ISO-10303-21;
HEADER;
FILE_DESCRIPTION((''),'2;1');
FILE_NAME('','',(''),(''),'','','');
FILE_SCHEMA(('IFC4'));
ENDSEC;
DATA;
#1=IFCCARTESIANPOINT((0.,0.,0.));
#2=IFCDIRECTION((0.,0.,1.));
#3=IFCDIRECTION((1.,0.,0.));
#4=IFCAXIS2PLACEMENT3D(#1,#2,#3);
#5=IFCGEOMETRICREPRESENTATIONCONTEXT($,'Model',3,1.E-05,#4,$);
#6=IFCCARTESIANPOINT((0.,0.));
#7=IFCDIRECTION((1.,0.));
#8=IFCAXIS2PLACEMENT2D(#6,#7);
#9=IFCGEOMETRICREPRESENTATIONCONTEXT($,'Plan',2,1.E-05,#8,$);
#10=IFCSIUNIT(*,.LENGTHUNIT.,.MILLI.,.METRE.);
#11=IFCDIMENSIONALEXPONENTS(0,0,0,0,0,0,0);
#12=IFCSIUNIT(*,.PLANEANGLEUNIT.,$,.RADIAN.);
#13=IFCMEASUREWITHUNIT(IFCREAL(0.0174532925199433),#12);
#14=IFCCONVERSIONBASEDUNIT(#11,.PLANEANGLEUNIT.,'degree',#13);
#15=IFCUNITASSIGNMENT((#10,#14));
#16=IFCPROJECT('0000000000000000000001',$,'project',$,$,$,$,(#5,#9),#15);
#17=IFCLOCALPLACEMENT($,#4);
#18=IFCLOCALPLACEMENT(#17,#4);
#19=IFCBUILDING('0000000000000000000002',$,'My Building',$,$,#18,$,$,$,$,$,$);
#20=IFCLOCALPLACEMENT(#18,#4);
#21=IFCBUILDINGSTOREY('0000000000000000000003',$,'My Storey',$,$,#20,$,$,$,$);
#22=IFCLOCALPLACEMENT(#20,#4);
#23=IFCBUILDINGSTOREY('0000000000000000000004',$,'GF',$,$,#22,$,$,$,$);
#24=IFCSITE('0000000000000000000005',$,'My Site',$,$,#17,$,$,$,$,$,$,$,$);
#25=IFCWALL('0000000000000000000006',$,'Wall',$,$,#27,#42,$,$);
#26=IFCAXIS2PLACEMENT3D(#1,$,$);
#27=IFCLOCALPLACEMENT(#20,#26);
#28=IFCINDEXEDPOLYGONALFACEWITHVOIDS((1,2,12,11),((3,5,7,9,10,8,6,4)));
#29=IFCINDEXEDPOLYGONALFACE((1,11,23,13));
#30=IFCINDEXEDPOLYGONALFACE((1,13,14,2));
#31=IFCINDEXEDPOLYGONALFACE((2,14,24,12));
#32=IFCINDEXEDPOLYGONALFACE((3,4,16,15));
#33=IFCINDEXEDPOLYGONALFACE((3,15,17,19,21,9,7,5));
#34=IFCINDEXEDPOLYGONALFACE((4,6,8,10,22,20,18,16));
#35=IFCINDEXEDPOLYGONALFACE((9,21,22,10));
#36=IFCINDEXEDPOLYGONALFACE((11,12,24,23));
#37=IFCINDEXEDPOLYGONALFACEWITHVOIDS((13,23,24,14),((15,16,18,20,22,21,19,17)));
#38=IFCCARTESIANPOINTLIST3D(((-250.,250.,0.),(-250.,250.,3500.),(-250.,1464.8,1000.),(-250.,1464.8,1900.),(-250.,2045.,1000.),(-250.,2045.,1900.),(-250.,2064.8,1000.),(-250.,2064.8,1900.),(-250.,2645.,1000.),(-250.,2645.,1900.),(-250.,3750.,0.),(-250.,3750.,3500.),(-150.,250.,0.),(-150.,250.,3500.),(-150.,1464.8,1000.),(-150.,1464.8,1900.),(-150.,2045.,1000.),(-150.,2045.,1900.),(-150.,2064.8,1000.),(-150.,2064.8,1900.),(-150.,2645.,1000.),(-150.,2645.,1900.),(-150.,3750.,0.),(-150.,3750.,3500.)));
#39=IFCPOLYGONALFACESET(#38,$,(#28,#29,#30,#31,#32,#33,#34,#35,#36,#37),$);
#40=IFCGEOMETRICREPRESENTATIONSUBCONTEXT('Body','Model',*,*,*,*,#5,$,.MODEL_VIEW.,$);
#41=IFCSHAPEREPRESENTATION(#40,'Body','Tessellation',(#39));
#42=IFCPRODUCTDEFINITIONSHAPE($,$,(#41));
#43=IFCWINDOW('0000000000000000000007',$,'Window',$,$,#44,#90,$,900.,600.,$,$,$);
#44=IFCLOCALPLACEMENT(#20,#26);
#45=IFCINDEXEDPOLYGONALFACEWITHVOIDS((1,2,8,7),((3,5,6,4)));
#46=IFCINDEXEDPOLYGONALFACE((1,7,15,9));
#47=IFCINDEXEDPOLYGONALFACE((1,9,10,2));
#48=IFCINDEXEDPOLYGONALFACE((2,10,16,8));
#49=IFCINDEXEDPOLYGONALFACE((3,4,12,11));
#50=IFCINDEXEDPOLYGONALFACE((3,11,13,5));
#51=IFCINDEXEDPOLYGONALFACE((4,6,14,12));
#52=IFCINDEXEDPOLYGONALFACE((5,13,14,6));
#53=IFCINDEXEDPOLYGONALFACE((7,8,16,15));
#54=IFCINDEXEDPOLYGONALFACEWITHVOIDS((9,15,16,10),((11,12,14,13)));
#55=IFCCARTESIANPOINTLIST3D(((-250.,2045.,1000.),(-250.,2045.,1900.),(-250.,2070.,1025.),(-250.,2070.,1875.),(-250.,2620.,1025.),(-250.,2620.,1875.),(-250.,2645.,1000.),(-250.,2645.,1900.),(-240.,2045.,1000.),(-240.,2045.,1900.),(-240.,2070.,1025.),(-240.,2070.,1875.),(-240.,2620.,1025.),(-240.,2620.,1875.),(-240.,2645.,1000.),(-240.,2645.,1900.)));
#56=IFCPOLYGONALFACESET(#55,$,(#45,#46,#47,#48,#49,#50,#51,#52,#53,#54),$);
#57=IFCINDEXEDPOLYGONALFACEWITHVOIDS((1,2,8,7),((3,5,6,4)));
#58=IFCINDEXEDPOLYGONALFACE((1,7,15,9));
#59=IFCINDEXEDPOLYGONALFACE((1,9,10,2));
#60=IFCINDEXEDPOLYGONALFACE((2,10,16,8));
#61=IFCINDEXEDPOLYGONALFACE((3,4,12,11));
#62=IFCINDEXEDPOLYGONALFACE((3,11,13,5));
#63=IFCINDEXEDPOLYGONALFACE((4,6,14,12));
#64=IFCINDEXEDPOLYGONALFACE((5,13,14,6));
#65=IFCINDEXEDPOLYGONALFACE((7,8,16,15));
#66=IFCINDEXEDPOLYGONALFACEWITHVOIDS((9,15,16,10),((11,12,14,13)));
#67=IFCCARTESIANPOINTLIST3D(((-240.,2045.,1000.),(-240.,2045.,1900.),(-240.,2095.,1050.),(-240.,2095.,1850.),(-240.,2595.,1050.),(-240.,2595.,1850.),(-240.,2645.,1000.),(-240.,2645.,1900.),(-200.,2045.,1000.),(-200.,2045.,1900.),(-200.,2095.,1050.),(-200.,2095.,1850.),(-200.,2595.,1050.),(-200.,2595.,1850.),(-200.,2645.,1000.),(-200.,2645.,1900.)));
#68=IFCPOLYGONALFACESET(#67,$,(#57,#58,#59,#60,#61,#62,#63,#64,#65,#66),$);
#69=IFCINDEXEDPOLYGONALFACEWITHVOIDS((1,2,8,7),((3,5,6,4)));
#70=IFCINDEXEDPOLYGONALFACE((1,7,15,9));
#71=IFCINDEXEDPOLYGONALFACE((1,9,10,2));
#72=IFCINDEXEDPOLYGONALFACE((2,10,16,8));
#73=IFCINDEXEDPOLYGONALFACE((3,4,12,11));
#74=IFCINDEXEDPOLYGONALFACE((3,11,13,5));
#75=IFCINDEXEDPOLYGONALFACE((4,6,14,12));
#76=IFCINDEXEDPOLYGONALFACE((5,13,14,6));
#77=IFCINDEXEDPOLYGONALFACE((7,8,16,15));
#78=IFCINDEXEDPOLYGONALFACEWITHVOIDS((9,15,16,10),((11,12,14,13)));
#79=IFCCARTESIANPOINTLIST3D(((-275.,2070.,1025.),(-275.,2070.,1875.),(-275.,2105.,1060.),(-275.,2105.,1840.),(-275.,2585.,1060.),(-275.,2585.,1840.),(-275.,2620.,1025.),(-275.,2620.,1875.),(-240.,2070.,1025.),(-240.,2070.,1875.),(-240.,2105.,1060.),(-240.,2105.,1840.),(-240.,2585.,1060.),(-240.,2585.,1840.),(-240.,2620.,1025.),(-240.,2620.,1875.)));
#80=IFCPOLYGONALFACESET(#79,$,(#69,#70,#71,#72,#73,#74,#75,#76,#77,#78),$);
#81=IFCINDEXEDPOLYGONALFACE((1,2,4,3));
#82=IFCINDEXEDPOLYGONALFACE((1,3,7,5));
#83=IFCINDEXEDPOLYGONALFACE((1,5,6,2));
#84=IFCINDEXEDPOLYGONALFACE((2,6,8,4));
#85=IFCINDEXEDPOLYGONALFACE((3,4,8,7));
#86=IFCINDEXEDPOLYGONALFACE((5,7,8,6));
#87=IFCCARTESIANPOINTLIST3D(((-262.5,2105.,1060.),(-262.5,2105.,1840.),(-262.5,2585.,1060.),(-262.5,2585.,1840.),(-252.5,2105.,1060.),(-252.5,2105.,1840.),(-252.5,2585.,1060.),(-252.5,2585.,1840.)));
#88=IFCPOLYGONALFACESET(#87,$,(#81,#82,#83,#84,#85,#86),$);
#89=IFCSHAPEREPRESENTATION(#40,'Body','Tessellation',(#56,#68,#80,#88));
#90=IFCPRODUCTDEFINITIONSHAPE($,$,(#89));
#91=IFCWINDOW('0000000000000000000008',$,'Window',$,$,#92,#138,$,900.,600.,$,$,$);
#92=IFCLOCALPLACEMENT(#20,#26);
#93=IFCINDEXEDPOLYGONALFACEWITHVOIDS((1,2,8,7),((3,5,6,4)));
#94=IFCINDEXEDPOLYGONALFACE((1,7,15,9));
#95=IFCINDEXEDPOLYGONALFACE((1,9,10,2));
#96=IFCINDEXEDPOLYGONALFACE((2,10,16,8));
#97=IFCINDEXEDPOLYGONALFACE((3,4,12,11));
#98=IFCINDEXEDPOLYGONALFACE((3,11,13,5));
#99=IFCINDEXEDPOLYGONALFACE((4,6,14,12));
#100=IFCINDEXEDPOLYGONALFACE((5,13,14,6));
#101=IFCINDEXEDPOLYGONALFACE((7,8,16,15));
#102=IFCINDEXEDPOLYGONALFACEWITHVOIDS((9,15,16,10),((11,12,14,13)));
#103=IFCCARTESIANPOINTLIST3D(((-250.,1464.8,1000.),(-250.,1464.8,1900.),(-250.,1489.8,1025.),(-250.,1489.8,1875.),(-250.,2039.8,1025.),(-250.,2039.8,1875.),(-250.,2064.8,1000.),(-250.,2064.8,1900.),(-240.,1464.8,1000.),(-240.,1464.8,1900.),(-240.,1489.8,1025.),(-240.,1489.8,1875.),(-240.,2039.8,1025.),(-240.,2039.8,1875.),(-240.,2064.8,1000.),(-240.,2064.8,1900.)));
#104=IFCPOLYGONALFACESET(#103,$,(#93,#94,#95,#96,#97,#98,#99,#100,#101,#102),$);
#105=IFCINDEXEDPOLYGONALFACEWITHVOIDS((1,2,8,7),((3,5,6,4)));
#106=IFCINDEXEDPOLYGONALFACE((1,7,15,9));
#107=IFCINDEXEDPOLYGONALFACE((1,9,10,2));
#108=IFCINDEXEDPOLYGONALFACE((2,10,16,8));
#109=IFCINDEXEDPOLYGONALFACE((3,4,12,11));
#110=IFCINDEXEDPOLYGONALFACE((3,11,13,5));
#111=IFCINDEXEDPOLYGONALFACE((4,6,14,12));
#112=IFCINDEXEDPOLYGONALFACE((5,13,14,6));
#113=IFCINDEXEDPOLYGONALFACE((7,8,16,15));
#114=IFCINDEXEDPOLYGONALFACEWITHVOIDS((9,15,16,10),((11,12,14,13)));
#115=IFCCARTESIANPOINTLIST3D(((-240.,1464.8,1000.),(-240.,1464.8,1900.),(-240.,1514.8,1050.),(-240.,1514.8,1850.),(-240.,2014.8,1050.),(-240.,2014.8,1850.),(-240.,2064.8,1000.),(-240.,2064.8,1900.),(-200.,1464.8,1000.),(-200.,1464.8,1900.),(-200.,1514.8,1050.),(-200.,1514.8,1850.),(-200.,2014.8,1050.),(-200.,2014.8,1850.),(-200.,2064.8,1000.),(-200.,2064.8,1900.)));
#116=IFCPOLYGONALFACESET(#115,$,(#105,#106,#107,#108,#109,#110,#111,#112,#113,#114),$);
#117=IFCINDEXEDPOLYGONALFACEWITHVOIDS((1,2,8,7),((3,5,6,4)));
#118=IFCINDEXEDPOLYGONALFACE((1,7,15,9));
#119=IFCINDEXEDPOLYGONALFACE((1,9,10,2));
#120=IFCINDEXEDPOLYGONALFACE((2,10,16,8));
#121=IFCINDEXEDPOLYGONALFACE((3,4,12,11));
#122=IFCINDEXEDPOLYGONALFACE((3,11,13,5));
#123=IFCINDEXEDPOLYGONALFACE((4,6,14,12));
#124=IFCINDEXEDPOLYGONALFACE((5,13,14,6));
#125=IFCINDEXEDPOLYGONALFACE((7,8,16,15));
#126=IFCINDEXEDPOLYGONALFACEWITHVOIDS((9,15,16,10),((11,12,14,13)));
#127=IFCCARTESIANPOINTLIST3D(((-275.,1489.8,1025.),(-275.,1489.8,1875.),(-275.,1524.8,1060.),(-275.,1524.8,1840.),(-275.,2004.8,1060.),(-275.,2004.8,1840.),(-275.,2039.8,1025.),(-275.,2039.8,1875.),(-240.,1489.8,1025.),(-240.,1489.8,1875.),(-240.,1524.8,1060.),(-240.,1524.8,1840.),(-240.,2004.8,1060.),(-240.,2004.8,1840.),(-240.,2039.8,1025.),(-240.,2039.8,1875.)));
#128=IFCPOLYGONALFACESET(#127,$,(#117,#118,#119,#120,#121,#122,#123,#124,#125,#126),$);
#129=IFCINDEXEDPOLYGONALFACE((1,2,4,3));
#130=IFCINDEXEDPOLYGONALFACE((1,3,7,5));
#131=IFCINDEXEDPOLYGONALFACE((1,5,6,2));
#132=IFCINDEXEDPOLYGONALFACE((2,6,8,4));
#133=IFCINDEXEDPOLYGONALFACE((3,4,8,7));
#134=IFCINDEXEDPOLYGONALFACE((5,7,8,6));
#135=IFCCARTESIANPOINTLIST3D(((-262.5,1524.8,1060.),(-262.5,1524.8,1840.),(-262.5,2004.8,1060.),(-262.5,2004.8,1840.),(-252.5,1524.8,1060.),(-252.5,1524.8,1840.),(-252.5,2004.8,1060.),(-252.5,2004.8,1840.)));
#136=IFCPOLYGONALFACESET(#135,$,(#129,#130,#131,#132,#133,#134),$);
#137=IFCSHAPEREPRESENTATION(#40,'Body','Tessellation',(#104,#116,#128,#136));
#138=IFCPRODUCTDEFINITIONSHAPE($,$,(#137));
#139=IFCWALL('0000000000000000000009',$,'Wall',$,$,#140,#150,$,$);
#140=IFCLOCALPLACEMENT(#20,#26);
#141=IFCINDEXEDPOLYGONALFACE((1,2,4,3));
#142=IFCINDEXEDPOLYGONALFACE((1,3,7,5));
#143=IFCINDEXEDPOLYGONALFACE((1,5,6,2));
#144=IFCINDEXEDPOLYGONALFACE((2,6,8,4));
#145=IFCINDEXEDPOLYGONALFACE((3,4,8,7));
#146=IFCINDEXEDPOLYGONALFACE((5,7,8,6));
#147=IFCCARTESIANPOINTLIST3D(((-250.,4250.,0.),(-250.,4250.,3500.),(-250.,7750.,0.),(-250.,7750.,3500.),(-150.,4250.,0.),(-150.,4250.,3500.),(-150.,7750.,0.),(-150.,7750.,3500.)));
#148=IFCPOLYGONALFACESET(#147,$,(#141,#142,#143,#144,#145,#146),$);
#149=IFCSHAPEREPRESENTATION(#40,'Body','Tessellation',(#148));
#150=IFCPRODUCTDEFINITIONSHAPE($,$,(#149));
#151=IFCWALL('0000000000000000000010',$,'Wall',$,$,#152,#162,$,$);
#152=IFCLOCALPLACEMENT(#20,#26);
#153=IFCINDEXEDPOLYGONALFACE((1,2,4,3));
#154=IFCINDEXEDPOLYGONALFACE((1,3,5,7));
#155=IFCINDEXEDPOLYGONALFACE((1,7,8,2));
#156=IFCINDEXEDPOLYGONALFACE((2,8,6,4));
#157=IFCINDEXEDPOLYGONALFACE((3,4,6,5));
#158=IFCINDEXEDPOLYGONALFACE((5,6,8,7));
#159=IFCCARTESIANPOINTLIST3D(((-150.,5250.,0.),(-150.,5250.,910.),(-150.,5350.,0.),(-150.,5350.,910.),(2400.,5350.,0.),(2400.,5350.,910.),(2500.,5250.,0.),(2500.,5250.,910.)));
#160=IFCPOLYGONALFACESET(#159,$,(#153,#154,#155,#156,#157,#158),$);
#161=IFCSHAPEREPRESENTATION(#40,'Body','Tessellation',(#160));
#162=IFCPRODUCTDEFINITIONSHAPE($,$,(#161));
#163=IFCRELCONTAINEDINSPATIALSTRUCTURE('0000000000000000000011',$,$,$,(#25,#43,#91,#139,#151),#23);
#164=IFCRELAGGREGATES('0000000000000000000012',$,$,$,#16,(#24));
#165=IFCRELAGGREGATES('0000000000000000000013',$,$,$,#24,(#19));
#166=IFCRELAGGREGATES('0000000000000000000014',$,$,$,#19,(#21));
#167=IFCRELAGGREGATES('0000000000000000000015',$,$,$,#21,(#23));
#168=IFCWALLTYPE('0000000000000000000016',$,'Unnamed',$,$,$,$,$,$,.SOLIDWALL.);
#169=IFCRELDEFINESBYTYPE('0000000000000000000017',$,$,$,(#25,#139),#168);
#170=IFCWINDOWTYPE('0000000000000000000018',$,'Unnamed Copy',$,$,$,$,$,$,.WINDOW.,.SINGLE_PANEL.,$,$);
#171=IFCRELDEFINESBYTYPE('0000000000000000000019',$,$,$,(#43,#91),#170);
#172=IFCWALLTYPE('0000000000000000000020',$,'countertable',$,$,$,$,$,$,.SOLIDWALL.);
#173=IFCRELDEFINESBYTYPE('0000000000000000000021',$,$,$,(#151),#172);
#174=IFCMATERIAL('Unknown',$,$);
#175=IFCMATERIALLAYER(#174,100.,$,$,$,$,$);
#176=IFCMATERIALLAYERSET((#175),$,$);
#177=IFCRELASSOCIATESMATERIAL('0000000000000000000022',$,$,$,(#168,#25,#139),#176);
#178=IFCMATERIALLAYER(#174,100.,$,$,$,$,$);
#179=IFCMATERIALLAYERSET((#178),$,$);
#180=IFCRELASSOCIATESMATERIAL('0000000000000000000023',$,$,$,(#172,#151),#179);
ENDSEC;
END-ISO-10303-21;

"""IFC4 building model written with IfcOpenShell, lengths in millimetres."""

from ifc_helpers import new_model, entity, si_unit, converted_unit, frame, origin_with_axes, origin_2d_with_axis, place, context, subcontext, project, spatial, line, indexed_curve, outline, extrude, shape, source, transform, mapped, material, layer, layer_set, layer_usage, type_object, type_shapes, element, fill, save


model = new_model("IFC4")

# Units and contexts
model_context = context("Model", 3, precision=1e-05, world=origin_with_axes())
plan_context = context("Plan", 2, precision=1e-05, world=origin_2d_with_axis())
body_context_1 = subcontext(model_context, "Body", "Model", "MODEL_VIEW")
body_context_2 = subcontext(plan_context, "Body", "Plan", "PLAN_VIEW")
ifc_project = project(units=[si_unit("LENGTHUNIT", "METRE", prefix="MILLI"), converted_unit("PLANEANGLEUNIT", "degree", entity("IfcReal", 0.0174532925199433), si_unit("PLANEANGLEUNIT", "RADIAN"), dimensions=[0, 0, 0, 0, 0, 0, 0])], contexts=[model_context, plan_context])

# Site, building, storeys
site_placement = place(None, origin_with_axes())
site = spatial("IfcSite", under=ifc_project, at=site_placement, Name="My Site")
building_placement = place(site_placement, origin_with_axes())
building = spatial("IfcBuilding", under=site, at=building_placement, Name="My Building")
storey_1_placement = place(building_placement, origin_with_axes())
storey_1 = spatial("IfcBuildingStorey", under=building, at=storey_1_placement, Name="My Storey")
storey_2_placement = place(storey_1_placement, origin_with_axes())
storey_2 = spatial("IfcBuildingStorey", under=storey_1, at=storey_2_placement, Name="GF")

# Shared definitions
ifc_material = material(Name="Unknown")

# Shared definitions
ifc_layer_1 = layer(ifc_material, 100.0)
ifc_layer_set_1 = layer_set([ifc_layer_1])
wall_type_1 = type_object("IfcWallType", Name="Unnamed", PredefinedType="SOLIDWALL", material=ifc_layer_set_1)

# Wall, openings, windows
ifc_layer_usage_1 = layer_usage(ifc_layer_set_1, "AXIS2", "POSITIVE", 0.0)
wall_1_placement = place(storey_2_placement, frame((-150.0, 250.0, 0.0), z_axis=(0.0, 0.0, 1.0), x_axis=(0.0, 1.0, 0.0)))
wall_1 = element("IfcWall", 1, at=wall_1_placement, inside=storey_2, type_object=wall_type_1, material=ifc_layer_usage_1, Name="Wall", context=body_context_1, shape_type="SweptSolid", body=[
    extrude(outline(indexed_curve([(0.0, 0.0), (0.0, 100.0), (3500.0, 100.0), (3500.0, 0.0)], segments=[line(1, 2, 3, 4, 1)])), origin_with_axes(), (0.0, 0.0, 1.0), 3500.0),
])
shared_shape_1 = source(origin_with_axes(), body_context_1, "Body", "SweptSolid", [
    extrude(outline(indexed_curve([(0.0, 0.0), (600.0, 0.0), (600.0, 900.0), (0.0, 900.0)], segments=[line(1, 2, 3, 4, 1)])), frame((0.0, -600.0, 0.0), z_axis=(0.0, -1.0, 0.0), x_axis=(1.0, 0.0, 0.0)), (0.0, 0.0, -1.0), 1200.0),
])
opening_1_placement = place(wall_1_placement, frame((1795.0, 0.0, 1000.0), z_axis=(0.0, 0.0, 1.0), x_axis=(1.0, 0.0, 0.0)))
opening_1 = element("IfcOpeningElement", 2, at=opening_1_placement, cuts=wall_1, PredefinedType="OPENING", context=body_context_1, shape_type="MappedRepresentation", body=[
    mapped(shared_shape_1, transform((0.0, 0.0, 0.0), x_axis=(1.0, 0.0, 0.0), y_axis=(0.0, 1.0, 0.0), z_axis=(0.0, 0.0, 1.0), scale=1.0)),
])
opening_2_placement = place(wall_1_placement, frame((1214.8, 0.0, 1000.0), z_axis=(0.0, 0.0, 1.0), x_axis=(1.0, 0.0, 0.0)))
opening_2 = element("IfcOpeningElement", 3, at=opening_2_placement, cuts=wall_1, PredefinedType="OPENING", context=body_context_1, shape_type="MappedRepresentation", body=[
    mapped(shared_shape_1, transform((0.0, 0.0, 0.0), x_axis=(1.0, 0.0, 0.0), y_axis=(0.0, 1.0, 0.0), z_axis=(0.0, 0.0, 1.0), scale=1.0)),
])
window_type_1 = type_object("IfcWindowType", Name="Unnamed Copy", PartitioningType="SINGLE_PANEL", PredefinedType="WINDOW")
shared_shape_2 = source(origin_with_axes(), body_context_1, "Body", "SweptSolid", [
    extrude(outline(indexed_curve([(0.0, 0.0), (600.0, 0.0), (600.0, 900.0), (0.0, 900.0)], segments=[line(1, 2, 3, 4, 1)]), holes=[indexed_curve([(25.0, 25.0), (575.0, 25.0), (575.0, 875.0), (25.0, 875.0)], segments=[line(1, 2, 3, 4, 1)])]), frame((0.0, 90.0, 0.0), z_axis=(0.0, -1.0, 0.0), x_axis=(1.0, 0.0, 0.0)), (0.0, 0.0, -1.0), 10.0),
    extrude(outline(indexed_curve([(0.0, 0.0), (600.0, 0.0), (600.0, 900.0), (0.0, 900.0)], segments=[line(1, 2, 3, 4, 1)]), holes=[indexed_curve([(50.0, 50.0), (550.0, 50.0), (550.0, 850.0), (50.0, 850.0)], segments=[line(1, 2, 3, 4, 1)])]), frame((0.0, 50.0, 0.0), z_axis=(0.0, -1.0, 0.0), x_axis=(1.0, 0.0, 0.0)), (0.0, 0.0, -1.0), 40.0),
    extrude(outline(indexed_curve([(0.0, 0.0), (550.0, 0.0), (550.0, 850.0), (0.0, 850.0)], segments=[line(1, 2, 3, 4, 1)]), holes=[indexed_curve([(35.0, 35.0), (515.0, 35.0), (515.0, 815.0), (35.0, 815.0)], segments=[line(1, 2, 3, 4, 1)])]), frame((25.0, 90.0, 25.0), z_axis=(0.0, -1.0, 0.0), x_axis=(1.0, 0.0, 0.0)), (0.0, 0.0, -1.0), 35.0),
    extrude(outline(indexed_curve([(35.0, 35.0), (515.0, 35.0), (515.0, 815.0), (35.0, 815.0)], segments=[line(1, 2, 3, 4, 1)])), frame((25.0, 102.5, 25.0), z_axis=(0.0, -1.0, 0.0), x_axis=(1.0, 0.0, 0.0)), (0.0, 0.0, -1.0), 10.0),
])
shared_shape_3 = source(origin_with_axes(), body_context_2, "Body", "Curve2D", [
    entity("IfcIndexedPolyCurve", entity("IfcCartesianPointList2D", [[50.0, 50.0], [550.0, 50.0]])),
    entity("IfcIndexedPolyCurve", entity("IfcCartesianPointList2D", [[0.0, 100.0], [25.0, 100.0], [25.0, 90.0], [50.0, 90.0], [50.0, 50.0], [0.0, 50.0]]), [entity("IfcLineIndex", [1, 2, 3, 4, 5, 6, 1])]),
    entity("IfcIndexedPolyCurve", entity("IfcCartesianPointList2D", [[600.0, 100.0], [575.0, 100.0], [575.0, 90.0], [550.0, 90.0], [550.0, 50.0], [600.0, 50.0]]), [entity("IfcLineIndex", [1, 2, 3, 4, 5, 6, 1])]),
    entity("IfcIndexedPolyCurve", entity("IfcCartesianPointList2D", [[25.0, 90.0], [60.0, 90.0], [60.0, 125.0], [25.0, 125.0]]), [entity("IfcLineIndex", [1, 2, 3, 4, 1])]),
    entity("IfcIndexedPolyCurve", entity("IfcCartesianPointList2D", [[575.0, 90.0], [540.0, 90.0], [540.0, 125.0], [575.0, 125.0]]), [entity("IfcLineIndex", [1, 2, 3, 4, 1])]),
    entity("IfcIndexedPolyCurve", entity("IfcCartesianPointList2D", [[60.0, 90.0], [540.0, 90.0]])),
    entity("IfcIndexedPolyCurve", entity("IfcCartesianPointList2D", [[60.0, 125.0], [540.0, 125.0]])),
    entity("IfcIndexedPolyCurve", entity("IfcCartesianPointList2D", [[60.0, 107.5], [540.0, 107.5]])),
])
type_shapes(window_type_1, [shared_shape_2, shared_shape_3])
window_1_placement = place(opening_1_placement, frame((0.0, 0.0, 0.0), z_axis=(0.0, 0.0, 1.0), x_axis=(1.0, 0.0, 0.0)))
window_1 = element("IfcWindow", 4, at=window_1_placement, inside=storey_2, type_object=window_type_1, Name="Window", OverallHeight=900.0, OverallWidth=600.0, shapes=[
    shape(body_context_1, "Body", "MappedRepresentation", [mapped(shared_shape_2, transform((0.0, 0.0, 0.0), x_axis=(1.0, 0.0, 0.0), y_axis=(0.0, 1.0, 0.0), z_axis=(0.0, 0.0, 1.0), scale=1.0))]),
    shape(body_context_2, "Body", "MappedRepresentation", [mapped(shared_shape_3, transform((0.0, 0.0, 0.0), x_axis=(1.0, 0.0, 0.0), y_axis=(0.0, 1.0, 0.0), z_axis=(0.0, 0.0, 1.0), scale=1.0))]),
])
fill(opening_1, window_1)
window_2_placement = place(opening_2_placement, frame((0.0, 0.0, 0.0), z_axis=(0.0, 0.0, 1.0), x_axis=(1.0, 0.0, 0.0)))
window_2 = element("IfcWindow", 5, at=window_2_placement, inside=storey_2, type_object=window_type_1, Name="Window", OverallHeight=900.0, OverallWidth=600.0, shapes=[
    shape(body_context_1, "Body", "MappedRepresentation", [mapped(shared_shape_2, transform((0.0, 0.0, 0.0), x_axis=(1.0, 0.0, 0.0), y_axis=(0.0, 1.0, 0.0), z_axis=(0.0, 0.0, 1.0), scale=1.0))]),
    shape(body_context_2, "Body", "MappedRepresentation", [mapped(shared_shape_3, transform((0.0, 0.0, 0.0), x_axis=(1.0, 0.0, 0.0), y_axis=(0.0, 1.0, 0.0), z_axis=(0.0, 0.0, 1.0), scale=1.0))]),
])
fill(opening_2, window_2)

# Walls
ifc_layer_usage_2 = layer_usage(ifc_layer_set_1, "AXIS2", "POSITIVE", 0.0)
wall_2_placement = place(storey_2_placement, frame((-250.0, 7750.0, 0.0), z_axis=(0.0, 0.0, 1.0), x_axis=(0.0, -1.0, 0.0)))
element("IfcWall", 6, at=wall_2_placement, inside=storey_2, type_object=wall_type_1, material=ifc_layer_usage_2, Name="Wall", context=body_context_1, shape_type="SweptSolid", body=[
    extrude(outline(indexed_curve([(0.0, 0.0), (0.0, 100.0), (3500.0, 100.0), (3500.0, 0.0)], segments=[line(1, 2, 3, 4, 1)])), origin_with_axes(), (0.0, 0.0, 1.0), 3500.0),
])
ifc_layer_2 = layer(ifc_material, 100.0)
ifc_layer_set_2 = layer_set([ifc_layer_2])
ifc_layer_usage_3 = layer_usage(ifc_layer_set_2, "AXIS2", "POSITIVE", 0.0)
wall_type_2 = type_object("IfcWallType", Name="countertable", PredefinedType="SOLIDWALL", material=ifc_layer_set_2)
wall_3_placement = place(storey_2_placement, frame((-150.0, 5250.0, 0.0), z_axis=(0.0, 0.0, 1.0), x_axis=(1.0, 0.0, 0.0)))
element("IfcWall", 7, at=wall_3_placement, inside=storey_2, type_object=wall_type_2, material=ifc_layer_usage_3, Name="Wall", context=body_context_1, shape_type="SweptSolid", body=[
    extrude(outline(indexed_curve([(0.0, 0.0), (0.0, 100.0), (2550.0, 100.0), (2650.0, 0.0)], segments=[line(1, 2, 3, 4, 1)])), origin_with_axes(), (0.0, 0.0, 1.0), 910.0),
])

save(model, "model.ifc")
